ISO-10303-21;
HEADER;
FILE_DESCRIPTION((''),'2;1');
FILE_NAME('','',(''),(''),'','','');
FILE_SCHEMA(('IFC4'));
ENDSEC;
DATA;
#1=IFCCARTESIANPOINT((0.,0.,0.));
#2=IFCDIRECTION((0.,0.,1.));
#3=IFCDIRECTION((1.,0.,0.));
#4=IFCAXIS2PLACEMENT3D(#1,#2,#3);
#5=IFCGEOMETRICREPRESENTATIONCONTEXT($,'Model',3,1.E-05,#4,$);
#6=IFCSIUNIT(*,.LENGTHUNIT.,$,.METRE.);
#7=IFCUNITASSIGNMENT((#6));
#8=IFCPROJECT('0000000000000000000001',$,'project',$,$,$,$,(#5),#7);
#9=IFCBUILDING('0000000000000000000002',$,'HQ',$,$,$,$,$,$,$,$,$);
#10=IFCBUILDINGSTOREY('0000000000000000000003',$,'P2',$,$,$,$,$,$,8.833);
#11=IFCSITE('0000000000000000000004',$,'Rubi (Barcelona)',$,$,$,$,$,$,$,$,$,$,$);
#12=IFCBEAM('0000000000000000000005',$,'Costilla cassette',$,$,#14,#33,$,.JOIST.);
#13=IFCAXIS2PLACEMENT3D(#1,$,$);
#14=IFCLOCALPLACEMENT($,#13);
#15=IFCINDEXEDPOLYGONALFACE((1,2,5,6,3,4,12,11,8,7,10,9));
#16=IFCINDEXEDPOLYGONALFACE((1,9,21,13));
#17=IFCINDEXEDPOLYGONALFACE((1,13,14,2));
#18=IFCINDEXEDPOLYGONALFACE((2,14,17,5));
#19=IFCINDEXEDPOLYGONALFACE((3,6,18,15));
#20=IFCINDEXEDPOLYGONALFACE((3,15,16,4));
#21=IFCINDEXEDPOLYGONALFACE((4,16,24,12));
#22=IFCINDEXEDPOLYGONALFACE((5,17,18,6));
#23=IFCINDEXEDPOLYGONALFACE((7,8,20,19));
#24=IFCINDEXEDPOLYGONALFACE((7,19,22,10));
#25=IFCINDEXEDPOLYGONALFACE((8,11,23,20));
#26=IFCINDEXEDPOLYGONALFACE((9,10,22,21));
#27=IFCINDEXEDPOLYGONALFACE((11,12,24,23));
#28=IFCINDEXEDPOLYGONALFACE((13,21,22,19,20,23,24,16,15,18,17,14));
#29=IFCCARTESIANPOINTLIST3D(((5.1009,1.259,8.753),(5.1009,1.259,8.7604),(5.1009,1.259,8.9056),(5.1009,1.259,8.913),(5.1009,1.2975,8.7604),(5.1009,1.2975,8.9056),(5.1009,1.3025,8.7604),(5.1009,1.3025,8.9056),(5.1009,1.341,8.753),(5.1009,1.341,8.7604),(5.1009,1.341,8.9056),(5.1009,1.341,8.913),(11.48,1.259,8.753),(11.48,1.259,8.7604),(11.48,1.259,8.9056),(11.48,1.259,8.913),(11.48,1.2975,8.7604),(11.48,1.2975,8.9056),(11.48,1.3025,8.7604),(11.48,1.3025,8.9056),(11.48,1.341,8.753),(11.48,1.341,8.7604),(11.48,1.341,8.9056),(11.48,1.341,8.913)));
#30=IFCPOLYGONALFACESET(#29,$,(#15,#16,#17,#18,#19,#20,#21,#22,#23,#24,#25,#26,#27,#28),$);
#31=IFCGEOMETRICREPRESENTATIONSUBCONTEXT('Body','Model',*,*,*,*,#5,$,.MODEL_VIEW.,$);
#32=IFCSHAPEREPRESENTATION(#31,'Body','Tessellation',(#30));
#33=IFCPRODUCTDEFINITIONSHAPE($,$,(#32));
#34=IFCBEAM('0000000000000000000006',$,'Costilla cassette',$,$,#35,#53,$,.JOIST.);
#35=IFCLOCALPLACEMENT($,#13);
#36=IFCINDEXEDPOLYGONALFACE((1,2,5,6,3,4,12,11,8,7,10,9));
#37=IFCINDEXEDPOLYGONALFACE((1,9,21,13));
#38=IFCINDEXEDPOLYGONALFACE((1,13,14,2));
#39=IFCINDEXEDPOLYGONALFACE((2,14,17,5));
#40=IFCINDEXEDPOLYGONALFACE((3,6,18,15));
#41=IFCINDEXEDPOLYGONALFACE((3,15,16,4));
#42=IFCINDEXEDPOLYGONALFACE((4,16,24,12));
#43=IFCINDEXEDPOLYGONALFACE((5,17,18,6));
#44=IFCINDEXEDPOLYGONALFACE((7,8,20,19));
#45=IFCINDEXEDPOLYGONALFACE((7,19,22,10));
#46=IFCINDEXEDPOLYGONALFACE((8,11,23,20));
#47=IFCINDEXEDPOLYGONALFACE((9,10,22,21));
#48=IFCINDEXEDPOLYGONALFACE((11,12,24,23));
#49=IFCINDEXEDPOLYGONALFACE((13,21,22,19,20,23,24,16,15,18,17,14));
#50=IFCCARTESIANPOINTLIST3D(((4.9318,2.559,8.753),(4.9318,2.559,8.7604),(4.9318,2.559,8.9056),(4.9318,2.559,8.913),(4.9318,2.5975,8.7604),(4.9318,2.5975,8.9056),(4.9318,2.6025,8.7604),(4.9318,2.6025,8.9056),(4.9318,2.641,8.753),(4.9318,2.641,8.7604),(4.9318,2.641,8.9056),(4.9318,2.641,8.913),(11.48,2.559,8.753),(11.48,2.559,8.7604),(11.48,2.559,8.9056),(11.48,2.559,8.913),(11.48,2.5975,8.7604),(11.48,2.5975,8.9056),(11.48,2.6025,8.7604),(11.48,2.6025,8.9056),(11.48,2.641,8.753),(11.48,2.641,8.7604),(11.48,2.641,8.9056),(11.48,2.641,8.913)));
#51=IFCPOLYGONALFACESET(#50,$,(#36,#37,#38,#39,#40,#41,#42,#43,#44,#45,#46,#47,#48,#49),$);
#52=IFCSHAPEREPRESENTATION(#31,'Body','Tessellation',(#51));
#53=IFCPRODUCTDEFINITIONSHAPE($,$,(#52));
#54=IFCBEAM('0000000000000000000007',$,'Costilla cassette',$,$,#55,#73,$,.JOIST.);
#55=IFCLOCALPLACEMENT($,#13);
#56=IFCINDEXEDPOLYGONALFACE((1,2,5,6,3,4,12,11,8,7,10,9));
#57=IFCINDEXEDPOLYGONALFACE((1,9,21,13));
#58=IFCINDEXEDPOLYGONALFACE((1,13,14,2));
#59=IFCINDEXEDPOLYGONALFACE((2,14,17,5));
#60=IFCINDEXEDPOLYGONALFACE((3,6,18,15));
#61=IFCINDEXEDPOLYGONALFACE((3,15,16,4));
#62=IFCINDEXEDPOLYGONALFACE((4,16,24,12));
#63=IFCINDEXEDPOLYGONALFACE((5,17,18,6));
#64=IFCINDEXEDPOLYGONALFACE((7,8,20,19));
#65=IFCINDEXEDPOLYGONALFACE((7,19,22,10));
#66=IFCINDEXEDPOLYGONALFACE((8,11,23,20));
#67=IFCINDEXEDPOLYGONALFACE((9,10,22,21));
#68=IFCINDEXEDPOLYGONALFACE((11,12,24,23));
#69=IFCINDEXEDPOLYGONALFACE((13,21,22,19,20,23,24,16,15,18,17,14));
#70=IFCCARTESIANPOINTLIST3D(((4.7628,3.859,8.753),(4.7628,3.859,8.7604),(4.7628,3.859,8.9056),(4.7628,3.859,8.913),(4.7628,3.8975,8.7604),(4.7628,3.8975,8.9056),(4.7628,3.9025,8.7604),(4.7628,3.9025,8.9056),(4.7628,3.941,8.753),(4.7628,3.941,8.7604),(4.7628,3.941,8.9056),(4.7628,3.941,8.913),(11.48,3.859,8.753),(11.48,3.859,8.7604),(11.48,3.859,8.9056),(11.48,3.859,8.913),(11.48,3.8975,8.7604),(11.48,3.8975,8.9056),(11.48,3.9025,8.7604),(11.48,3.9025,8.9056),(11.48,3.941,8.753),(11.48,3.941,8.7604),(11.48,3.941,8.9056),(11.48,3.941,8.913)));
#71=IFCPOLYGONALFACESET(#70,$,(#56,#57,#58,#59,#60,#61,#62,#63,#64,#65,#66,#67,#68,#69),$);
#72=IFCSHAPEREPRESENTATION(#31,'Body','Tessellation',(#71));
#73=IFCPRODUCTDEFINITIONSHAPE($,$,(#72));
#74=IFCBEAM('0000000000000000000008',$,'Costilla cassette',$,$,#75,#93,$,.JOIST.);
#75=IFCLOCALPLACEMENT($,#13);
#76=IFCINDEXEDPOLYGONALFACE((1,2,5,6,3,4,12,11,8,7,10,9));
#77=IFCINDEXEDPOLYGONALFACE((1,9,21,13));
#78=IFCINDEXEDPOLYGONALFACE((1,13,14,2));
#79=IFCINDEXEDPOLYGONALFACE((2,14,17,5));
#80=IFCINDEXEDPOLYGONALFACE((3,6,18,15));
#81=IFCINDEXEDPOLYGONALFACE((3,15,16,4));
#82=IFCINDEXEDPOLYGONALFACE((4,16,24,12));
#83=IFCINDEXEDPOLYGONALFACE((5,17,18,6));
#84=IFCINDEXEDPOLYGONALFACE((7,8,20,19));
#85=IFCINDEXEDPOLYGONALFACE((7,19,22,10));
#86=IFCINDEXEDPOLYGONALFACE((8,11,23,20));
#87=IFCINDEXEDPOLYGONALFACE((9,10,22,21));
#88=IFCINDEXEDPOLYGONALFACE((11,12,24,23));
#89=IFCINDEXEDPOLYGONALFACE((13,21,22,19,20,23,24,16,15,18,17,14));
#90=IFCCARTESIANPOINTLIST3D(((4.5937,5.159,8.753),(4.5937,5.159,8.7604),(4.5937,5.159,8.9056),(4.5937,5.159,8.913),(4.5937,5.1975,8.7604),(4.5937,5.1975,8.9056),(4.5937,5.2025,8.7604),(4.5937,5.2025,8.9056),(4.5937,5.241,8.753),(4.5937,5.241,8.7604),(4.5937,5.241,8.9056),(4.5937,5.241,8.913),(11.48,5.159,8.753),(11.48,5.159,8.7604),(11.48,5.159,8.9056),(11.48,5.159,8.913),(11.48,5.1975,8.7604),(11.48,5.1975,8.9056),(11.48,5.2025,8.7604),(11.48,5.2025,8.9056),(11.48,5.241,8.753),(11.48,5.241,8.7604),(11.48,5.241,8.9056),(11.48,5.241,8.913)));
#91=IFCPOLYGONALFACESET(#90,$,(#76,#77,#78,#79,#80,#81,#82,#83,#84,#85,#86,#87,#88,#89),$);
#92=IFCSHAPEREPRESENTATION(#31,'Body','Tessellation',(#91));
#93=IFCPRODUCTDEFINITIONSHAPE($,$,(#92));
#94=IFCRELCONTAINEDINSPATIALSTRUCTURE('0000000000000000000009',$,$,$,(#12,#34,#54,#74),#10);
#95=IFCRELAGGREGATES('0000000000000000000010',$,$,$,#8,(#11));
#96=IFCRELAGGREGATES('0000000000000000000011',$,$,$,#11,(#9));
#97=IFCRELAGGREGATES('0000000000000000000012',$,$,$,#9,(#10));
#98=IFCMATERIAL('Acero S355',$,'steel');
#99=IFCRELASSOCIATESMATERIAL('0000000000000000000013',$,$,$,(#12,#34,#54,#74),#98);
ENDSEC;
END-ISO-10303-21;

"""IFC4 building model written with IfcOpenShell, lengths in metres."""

from ifc_helpers import new_model, si_unit, frame, origin_with_axes, place, context, subcontext, project, spatial, i_section, extrude, material, element, save


model = new_model("IFC4")

# Units and contexts
model_context = context("Model", 3, precision=1e-05, world=origin_with_axes())
body_context = subcontext(model_context, "Body", "Model", "MODEL_VIEW")
ifc_project = project(units=[si_unit("LENGTHUNIT", "METRE")], contexts=[model_context])

# Site, building, storey
site = spatial("IfcSite", under=ifc_project, Name="Rubi (Barcelona)")
building = spatial("IfcBuilding", under=site, Name="HQ")
storey = spatial("IfcBuildingStorey", under=building, Name="P2", Elevation=8.833)

# Shared definitions
ifc_material = material(Name="Acero S355", Category="steel")

# Beams
beam_1_placement = place(None, origin_with_axes())
element("IfcBeam", 1, at=beam_1_placement, inside=storey, material=ifc_material, Name="Costilla cassette", PredefinedType="JOIST", context=body_context, shape_type="SweptSolid", body=[
    extrude(i_section(OverallWidth=0.082, OverallDepth=0.16, WebThickness=0.005, FlangeThickness=0.0074), frame((5.1009, 1.3, 8.833), z_axis=(1.0, 0.0, 0.0), x_axis=(0.0, 1.0, 0.0)), (0.0, 0.0, 1.0), 6.3791),
])
beam_2_placement = place(None, origin_with_axes())
element("IfcBeam", 2, at=beam_2_placement, inside=storey, material=ifc_material, Name="Costilla cassette", PredefinedType="JOIST", context=body_context, shape_type="SweptSolid", body=[
    extrude(i_section(OverallWidth=0.082, OverallDepth=0.16, WebThickness=0.005, FlangeThickness=0.0074), frame((4.9318, 2.6, 8.833), z_axis=(1.0, 0.0, 0.0), x_axis=(0.0, 1.0, 0.0)), (0.0, 0.0, 1.0), 6.5482),
])
beam_3_placement = place(None, origin_with_axes())
element("IfcBeam", 3, at=beam_3_placement, inside=storey, material=ifc_material, Name="Costilla cassette", PredefinedType="JOIST", context=body_context, shape_type="SweptSolid", body=[
    extrude(i_section(OverallWidth=0.082, OverallDepth=0.16, WebThickness=0.005, FlangeThickness=0.0074), frame((4.7628, 3.9, 8.833), z_axis=(1.0, 0.0, 0.0), x_axis=(0.0, 1.0, 0.0)), (0.0, 0.0, 1.0), 6.7172),
])
beam_4_placement = place(None, origin_with_axes())
element("IfcBeam", 4, at=beam_4_placement, inside=storey, material=ifc_material, Name="Costilla cassette", PredefinedType="JOIST", context=body_context, shape_type="SweptSolid", body=[
    extrude(i_section(OverallWidth=0.082, OverallDepth=0.16, WebThickness=0.005, FlangeThickness=0.0074), frame((4.5937, 5.2, 8.833), z_axis=(1.0, 0.0, 0.0), x_axis=(0.0, 1.0, 0.0)), (0.0, 0.0, 1.0), 6.8863),
])

save(model, "model.ifc")
